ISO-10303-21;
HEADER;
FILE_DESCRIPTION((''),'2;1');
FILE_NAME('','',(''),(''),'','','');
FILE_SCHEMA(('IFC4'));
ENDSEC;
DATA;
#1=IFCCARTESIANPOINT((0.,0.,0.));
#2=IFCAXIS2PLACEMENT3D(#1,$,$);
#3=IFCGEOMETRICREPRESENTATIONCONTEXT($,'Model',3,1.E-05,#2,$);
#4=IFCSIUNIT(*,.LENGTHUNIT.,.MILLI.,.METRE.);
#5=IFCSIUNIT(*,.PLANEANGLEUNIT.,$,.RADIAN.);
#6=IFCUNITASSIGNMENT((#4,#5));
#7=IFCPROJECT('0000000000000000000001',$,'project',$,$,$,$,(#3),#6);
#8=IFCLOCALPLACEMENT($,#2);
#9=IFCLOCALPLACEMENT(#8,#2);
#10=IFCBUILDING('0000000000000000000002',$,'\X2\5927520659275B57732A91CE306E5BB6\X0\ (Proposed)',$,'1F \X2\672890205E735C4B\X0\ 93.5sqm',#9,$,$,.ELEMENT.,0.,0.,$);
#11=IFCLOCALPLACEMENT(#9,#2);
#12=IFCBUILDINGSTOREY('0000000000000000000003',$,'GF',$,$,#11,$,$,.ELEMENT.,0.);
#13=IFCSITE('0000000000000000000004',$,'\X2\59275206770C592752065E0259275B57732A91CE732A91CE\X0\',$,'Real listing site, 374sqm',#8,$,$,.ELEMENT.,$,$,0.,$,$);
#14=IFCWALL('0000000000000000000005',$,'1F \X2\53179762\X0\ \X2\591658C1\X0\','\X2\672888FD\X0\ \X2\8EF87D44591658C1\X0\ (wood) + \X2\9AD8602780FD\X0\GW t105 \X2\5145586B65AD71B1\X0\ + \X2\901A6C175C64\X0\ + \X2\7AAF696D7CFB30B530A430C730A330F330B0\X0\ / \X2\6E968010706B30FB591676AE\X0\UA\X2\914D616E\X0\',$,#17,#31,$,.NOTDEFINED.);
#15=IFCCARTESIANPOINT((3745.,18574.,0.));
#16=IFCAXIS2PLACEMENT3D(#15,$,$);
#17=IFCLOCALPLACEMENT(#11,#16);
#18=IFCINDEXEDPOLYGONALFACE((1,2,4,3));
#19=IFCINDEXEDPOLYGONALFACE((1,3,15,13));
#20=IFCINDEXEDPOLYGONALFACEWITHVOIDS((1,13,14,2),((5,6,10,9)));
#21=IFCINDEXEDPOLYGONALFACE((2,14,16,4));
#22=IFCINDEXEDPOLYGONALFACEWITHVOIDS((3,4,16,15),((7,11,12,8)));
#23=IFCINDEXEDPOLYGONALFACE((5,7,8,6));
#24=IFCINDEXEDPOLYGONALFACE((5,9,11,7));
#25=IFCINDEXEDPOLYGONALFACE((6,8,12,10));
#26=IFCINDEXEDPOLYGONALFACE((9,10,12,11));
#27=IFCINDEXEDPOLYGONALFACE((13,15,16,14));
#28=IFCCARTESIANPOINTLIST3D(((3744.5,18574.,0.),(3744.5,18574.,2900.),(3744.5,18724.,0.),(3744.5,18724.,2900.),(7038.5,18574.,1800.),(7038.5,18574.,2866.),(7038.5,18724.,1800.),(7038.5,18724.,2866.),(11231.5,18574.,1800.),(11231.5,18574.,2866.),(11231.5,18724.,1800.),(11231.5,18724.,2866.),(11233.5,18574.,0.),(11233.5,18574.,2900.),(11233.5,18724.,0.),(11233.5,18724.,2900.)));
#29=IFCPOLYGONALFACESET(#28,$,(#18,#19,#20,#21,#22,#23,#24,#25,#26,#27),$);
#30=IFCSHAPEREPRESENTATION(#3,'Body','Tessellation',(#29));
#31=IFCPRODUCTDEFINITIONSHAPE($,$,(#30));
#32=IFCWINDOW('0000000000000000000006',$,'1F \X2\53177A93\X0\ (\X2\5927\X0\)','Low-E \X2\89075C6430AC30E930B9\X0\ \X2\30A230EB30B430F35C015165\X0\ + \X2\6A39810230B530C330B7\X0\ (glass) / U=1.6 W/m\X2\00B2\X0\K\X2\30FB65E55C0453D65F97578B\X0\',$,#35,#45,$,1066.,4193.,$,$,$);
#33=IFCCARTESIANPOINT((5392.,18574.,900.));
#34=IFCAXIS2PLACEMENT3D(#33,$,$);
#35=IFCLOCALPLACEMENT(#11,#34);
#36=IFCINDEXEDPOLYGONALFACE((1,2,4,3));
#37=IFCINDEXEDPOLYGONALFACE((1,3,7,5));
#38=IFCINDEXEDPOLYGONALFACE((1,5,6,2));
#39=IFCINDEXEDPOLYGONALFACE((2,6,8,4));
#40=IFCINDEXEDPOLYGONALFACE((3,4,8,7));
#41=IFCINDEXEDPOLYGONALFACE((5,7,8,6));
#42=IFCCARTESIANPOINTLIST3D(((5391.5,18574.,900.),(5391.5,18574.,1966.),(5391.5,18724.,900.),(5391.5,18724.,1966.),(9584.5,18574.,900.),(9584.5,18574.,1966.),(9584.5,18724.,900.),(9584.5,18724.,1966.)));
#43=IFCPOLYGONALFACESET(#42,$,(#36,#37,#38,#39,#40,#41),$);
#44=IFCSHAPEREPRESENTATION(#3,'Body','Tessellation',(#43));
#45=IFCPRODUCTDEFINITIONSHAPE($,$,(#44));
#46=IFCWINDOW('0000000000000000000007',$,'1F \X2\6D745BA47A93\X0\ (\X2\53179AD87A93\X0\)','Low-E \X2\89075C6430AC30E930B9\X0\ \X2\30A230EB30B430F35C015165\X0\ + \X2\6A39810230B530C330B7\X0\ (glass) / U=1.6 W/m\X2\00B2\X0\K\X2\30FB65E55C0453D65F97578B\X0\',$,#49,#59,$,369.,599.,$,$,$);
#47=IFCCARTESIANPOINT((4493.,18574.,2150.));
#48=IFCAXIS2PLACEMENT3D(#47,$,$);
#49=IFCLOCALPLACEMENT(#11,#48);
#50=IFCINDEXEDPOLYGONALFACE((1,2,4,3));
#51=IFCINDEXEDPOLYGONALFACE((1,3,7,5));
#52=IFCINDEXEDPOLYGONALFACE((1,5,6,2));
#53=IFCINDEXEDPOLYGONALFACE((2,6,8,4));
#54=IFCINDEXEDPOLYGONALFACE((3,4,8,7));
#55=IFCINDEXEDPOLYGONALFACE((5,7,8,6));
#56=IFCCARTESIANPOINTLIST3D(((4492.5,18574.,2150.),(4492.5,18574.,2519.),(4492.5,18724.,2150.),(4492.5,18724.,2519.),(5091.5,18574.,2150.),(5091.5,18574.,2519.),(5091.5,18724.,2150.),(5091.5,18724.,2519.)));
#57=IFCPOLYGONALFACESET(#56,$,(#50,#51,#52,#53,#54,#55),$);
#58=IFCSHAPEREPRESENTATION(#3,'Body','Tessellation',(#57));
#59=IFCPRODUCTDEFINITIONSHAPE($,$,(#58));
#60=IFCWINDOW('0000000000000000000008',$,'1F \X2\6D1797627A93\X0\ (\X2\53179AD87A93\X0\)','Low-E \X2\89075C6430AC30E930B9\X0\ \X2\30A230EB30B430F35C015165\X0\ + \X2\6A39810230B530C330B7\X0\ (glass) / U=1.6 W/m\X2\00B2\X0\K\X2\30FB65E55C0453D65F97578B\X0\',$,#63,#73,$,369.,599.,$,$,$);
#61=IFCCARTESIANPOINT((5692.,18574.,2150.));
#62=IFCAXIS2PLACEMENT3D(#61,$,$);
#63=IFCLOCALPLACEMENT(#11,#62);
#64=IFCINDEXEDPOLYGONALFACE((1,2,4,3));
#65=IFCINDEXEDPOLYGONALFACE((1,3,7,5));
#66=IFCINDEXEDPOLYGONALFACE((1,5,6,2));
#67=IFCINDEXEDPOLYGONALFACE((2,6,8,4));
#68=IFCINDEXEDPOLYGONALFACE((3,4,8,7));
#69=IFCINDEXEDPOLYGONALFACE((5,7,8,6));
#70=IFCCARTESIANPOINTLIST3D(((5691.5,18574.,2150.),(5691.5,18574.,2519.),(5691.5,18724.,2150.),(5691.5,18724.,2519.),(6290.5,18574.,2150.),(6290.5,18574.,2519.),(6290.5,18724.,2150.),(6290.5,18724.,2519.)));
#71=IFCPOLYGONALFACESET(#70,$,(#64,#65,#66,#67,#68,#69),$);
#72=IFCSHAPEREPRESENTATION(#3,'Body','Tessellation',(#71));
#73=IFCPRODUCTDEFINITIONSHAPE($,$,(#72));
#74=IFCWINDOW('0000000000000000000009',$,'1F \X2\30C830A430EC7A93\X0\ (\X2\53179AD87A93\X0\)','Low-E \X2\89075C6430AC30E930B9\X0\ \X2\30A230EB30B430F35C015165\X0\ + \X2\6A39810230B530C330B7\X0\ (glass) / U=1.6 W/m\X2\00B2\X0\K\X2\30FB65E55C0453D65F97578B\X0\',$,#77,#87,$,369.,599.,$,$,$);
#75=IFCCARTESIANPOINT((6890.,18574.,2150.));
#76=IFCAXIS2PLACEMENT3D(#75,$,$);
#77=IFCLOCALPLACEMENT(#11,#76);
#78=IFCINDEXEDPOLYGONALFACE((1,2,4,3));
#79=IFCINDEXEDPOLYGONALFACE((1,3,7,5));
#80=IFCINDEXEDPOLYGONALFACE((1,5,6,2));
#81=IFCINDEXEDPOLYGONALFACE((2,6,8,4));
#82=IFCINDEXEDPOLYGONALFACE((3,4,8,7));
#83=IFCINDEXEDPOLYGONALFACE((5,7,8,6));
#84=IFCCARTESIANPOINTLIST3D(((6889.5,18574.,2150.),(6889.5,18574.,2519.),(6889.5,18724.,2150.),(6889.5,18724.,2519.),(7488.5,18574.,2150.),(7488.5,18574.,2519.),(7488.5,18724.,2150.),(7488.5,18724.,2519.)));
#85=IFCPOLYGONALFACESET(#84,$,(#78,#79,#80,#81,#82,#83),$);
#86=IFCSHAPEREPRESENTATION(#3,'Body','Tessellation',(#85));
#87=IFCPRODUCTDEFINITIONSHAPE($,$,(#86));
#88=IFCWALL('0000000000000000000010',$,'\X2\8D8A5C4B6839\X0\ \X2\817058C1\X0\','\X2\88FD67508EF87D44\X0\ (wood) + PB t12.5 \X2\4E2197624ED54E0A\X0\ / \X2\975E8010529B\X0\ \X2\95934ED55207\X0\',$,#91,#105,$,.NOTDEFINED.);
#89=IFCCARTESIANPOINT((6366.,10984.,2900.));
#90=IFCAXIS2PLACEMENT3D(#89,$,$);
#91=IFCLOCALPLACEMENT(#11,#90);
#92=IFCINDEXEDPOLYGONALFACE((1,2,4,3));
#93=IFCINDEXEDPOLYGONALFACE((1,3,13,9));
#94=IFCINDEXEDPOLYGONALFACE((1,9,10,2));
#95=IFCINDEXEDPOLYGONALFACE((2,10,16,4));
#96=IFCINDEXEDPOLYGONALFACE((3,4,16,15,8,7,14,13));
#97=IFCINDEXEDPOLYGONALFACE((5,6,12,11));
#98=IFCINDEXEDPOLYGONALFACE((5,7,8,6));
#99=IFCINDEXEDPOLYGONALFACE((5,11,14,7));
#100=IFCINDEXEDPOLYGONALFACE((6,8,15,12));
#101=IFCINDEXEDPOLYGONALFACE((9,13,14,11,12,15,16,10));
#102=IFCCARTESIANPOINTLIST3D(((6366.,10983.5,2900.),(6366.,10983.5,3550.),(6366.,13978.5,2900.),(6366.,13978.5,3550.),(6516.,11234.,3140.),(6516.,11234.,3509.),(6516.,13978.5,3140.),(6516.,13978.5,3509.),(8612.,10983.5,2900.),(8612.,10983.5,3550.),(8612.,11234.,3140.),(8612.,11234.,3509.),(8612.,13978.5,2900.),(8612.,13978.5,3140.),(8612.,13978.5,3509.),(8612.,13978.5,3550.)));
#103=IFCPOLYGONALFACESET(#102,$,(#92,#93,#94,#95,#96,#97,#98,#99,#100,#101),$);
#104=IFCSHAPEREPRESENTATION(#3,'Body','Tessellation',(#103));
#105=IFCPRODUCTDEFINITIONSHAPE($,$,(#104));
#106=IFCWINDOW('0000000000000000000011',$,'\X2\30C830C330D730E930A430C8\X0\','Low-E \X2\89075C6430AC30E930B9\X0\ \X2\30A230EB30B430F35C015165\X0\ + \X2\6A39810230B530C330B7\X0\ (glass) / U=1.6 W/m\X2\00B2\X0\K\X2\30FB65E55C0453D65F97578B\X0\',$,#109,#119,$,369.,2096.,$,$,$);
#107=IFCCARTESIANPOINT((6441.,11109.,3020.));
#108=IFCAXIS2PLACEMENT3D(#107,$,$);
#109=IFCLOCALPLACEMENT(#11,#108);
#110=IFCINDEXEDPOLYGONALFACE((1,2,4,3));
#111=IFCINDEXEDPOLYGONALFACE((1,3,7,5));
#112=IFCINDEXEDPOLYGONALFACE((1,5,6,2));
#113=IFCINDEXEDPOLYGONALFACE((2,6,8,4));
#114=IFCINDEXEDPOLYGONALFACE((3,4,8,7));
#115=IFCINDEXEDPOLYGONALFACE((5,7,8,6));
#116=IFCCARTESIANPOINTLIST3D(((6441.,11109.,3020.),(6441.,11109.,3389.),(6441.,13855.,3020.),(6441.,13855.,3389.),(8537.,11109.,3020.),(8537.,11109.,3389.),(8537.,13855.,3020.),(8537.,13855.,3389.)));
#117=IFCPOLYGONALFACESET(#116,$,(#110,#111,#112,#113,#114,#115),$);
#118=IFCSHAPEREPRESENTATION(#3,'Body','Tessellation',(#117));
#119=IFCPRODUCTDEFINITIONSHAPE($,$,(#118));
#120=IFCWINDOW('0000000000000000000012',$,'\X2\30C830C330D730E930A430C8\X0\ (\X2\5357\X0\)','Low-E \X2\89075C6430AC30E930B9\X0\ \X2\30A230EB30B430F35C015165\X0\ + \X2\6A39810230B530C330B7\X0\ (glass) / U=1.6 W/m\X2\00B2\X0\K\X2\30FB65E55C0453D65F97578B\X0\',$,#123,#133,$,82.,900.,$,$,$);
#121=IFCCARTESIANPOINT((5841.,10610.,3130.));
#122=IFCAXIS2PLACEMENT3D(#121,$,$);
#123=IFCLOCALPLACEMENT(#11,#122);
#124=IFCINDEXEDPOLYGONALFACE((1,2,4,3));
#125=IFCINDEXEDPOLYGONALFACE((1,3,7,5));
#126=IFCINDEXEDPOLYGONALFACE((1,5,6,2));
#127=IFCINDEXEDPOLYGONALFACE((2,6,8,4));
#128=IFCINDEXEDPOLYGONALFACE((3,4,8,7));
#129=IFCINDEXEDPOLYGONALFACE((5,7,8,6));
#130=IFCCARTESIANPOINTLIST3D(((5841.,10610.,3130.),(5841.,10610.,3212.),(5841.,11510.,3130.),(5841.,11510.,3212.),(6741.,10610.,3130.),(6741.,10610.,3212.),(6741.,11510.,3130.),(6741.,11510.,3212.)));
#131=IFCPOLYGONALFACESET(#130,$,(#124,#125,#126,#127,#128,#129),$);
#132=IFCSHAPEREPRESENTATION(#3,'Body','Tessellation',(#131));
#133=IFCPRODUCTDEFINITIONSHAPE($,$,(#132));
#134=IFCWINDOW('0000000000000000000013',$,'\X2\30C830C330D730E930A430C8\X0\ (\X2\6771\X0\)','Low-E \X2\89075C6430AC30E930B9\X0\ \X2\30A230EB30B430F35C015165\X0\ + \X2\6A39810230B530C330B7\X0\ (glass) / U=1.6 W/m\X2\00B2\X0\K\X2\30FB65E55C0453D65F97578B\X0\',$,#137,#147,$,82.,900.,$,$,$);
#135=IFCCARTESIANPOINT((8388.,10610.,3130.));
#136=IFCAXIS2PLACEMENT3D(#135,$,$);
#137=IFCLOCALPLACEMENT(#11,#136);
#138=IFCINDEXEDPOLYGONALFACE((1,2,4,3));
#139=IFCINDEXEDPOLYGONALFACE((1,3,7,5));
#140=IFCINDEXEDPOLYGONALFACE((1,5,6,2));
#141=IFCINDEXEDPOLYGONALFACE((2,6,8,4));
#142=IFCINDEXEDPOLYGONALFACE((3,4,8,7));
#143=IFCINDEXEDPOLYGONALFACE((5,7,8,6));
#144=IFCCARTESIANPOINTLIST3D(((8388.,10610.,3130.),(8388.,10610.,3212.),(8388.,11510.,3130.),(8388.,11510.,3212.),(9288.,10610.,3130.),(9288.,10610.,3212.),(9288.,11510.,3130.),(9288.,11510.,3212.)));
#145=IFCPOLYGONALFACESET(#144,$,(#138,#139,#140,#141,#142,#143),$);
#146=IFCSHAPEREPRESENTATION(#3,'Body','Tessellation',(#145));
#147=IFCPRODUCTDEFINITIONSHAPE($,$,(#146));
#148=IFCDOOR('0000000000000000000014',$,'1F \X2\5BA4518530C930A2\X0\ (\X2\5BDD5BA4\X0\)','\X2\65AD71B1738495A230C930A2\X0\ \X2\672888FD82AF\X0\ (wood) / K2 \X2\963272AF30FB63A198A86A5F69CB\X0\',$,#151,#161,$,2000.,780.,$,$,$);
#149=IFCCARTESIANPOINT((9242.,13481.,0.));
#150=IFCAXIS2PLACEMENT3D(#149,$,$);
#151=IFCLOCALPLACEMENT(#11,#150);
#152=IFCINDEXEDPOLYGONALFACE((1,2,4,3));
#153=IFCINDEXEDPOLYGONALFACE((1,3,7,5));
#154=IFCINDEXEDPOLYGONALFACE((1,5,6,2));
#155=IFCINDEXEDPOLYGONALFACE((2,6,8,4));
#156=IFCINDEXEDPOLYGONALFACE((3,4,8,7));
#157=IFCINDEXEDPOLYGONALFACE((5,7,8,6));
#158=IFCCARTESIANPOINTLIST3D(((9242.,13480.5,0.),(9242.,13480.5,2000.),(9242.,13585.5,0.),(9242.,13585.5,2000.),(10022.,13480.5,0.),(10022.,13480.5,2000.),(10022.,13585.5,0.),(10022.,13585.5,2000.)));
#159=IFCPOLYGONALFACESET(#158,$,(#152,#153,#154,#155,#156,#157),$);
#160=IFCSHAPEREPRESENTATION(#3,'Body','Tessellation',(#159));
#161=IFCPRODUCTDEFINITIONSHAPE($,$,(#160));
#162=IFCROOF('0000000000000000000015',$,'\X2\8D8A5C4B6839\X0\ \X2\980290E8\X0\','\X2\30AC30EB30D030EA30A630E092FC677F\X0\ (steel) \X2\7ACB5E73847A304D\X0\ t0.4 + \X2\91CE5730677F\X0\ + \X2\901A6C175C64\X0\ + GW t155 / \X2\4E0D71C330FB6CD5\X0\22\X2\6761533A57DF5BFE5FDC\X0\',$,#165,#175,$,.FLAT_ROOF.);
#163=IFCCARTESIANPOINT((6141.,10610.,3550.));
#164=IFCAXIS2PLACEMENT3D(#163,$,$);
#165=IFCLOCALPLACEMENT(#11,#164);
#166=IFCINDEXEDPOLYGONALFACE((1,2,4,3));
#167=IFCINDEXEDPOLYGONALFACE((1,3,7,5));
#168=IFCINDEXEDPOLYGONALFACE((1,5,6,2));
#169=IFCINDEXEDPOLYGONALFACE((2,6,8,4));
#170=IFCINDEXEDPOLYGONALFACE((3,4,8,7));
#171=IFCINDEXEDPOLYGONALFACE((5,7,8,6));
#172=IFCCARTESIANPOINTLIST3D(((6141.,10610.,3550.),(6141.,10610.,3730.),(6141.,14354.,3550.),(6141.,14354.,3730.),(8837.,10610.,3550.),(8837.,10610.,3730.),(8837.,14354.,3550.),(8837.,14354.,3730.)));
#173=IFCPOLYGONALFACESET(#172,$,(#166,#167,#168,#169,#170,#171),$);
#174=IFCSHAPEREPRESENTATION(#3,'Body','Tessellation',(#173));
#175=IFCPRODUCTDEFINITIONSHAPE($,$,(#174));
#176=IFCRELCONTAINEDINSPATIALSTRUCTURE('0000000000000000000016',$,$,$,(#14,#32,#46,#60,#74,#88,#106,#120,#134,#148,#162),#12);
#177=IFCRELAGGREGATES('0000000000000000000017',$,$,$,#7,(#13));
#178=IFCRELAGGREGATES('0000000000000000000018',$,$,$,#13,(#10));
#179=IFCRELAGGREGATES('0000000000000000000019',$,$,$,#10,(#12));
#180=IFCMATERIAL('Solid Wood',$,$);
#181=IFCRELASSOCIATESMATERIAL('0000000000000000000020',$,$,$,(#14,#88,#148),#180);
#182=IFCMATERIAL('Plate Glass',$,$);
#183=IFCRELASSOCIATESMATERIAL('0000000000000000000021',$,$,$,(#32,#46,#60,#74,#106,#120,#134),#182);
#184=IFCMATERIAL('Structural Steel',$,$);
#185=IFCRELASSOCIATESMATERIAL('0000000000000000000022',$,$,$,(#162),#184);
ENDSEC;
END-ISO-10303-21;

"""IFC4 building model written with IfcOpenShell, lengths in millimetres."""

from ifc_helpers import new_model, si_unit, frame, frame_2d, origin, place, context, project, spatial, rectangle, extrude, material, element, fill, save


model = new_model("IFC4")

# Units and contexts
model_context = context("Model", 3, precision=1e-05, world=origin())
ifc_project = project(units=[si_unit("LENGTHUNIT", "METRE", prefix="MILLI"), si_unit("PLANEANGLEUNIT", "RADIAN")], contexts=[model_context])

# Site, building, storey
site_placement = place(None, origin())
site = spatial("IfcSite", under=ifc_project, at=site_placement, Name="大分県大分市大字猪野猪野", ObjectType="Real listing site, 374sqm", CompositionType="ELEMENT", RefElevation=0.0)
building_placement = place(site_placement, origin())
building = spatial("IfcBuilding", under=site, at=building_placement, Name="大分大字猪野の家 (Proposed)", ObjectType="1F 木造平屋 93.5sqm", CompositionType="ELEMENT", ElevationOfRefHeight=0.0, ElevationOfTerrain=0.0)
storey_placement = place(building_placement, origin())
storey = spatial("IfcBuildingStorey", under=building, at=storey_placement, Name="GF", CompositionType="ELEMENT", Elevation=0.0)

# Shared definitions
ifc_material_1 = material(Name="Solid Wood")

# Wall, openings, windows
wall_1_placement = place(storey_placement, frame((3745.0, 18574.0, 0.0)))
wall_1 = element("IfcWall", 1, at=wall_1_placement, inside=storey, material=ifc_material_1, Name="1F 北面 外壁", Description="木製 軸組外壁 (wood) + 高性能GW t105 充填断熱 + 通気層 + 窯業系サイディング / 準耐火・外皮UA配慮", PredefinedType="NOTDEFINED", context=model_context, shape_type="SweptSolid", body=[
    extrude(rectangle(XDim=7489.0, YDim=150.0, at=frame_2d((3744.0, 75.0))), frame((3745.0, 18574.0, 0.0)), (0.0, 0.0, 1.0), 2900.0),
])
opening_1_placement = place(storey_placement, frame((5392.0, 18574.0, 900.0)))
opening_1 = element("IfcOpeningElement", 2, at=opening_1_placement, cuts=wall_1, PredefinedType="NOTDEFINED", context=model_context, shape_type="SweptSolid", body=[
    extrude(rectangle(XDim=4193.0, YDim=150.0, at=frame_2d((2096.0, 75.0))), frame((5392.0, 18574.0, 900.0)), (0.0, 0.0, 1.0), 1066.0),
])
opening_2_placement = place(storey_placement, frame((4493.0, 18574.0, 2150.0)))
opening_2 = element("IfcOpeningElement", 3, at=opening_2_placement, cuts=wall_1, PredefinedType="NOTDEFINED", context=model_context, shape_type="SweptSolid", body=[
    extrude(rectangle(XDim=599.0, YDim=150.0, at=frame_2d((299.0, 75.0))), frame((4493.0, 18574.0, 2150.0)), (0.0, 0.0, 1.0), 369.0),
])
opening_3_placement = place(storey_placement, frame((5692.0, 18574.0, 2150.0)))
opening_3 = element("IfcOpeningElement", 4, at=opening_3_placement, cuts=wall_1, PredefinedType="NOTDEFINED", context=model_context, shape_type="SweptSolid", body=[
    extrude(rectangle(XDim=599.0, YDim=150.0, at=frame_2d((299.0, 75.0))), frame((5692.0, 18574.0, 2150.0)), (0.0, 0.0, 1.0), 369.0),
])
opening_4_placement = place(storey_placement, frame((6890.0, 18574.0, 2150.0)))
opening_4 = element("IfcOpeningElement", 5, at=opening_4_placement, cuts=wall_1, PredefinedType="NOTDEFINED", context=model_context, shape_type="SweptSolid", body=[
    extrude(rectangle(XDim=599.0, YDim=150.0, at=frame_2d((299.0, 75.0))), frame((6890.0, 18574.0, 2150.0)), (0.0, 0.0, 1.0), 369.0),
])
ifc_material_2 = material(Name="Plate Glass")
window_1_placement = place(storey_placement, frame((5392.0, 18574.0, 900.0)))
window_1 = element("IfcWindow", 6, at=window_1_placement, inside=storey, material=ifc_material_2, Name="1F 北窓 (大)", Description="Low-E 複層ガラス アルゴン封入 + 樹脂サッシ (glass) / U=1.6 W/m²K・日射取得型", OverallHeight=1066.0, OverallWidth=4193.0, context=model_context, shape_type="SweptSolid", body=[
    extrude(rectangle(XDim=4193.0, YDim=150.0, at=frame_2d((2096.0, 75.0))), frame((5392.0, 18574.0, 900.0)), (0.0, 0.0, 1.0), 1066.0),
])
fill(opening_1, window_1)
window_2_placement = place(storey_placement, frame((4493.0, 18574.0, 2150.0)))
window_2 = element("IfcWindow", 7, at=window_2_placement, inside=storey, material=ifc_material_2, Name="1F 浴室窓 (北高窓)", Description="Low-E 複層ガラス アルゴン封入 + 樹脂サッシ (glass) / U=1.6 W/m²K・日射取得型", OverallHeight=369.0, OverallWidth=599.0, context=model_context, shape_type="SweptSolid", body=[
    extrude(rectangle(XDim=599.0, YDim=150.0, at=frame_2d((299.0, 75.0))), frame((4493.0, 18574.0, 2150.0)), (0.0, 0.0, 1.0), 369.0),
])
fill(opening_2, window_2)
window_3_placement = place(storey_placement, frame((5692.0, 18574.0, 2150.0)))
window_3 = element("IfcWindow", 8, at=window_3_placement, inside=storey, material=ifc_material_2, Name="1F 洗面窓 (北高窓)", Description="Low-E 複層ガラス アルゴン封入 + 樹脂サッシ (glass) / U=1.6 W/m²K・日射取得型", OverallHeight=369.0, OverallWidth=599.0, context=model_context, shape_type="SweptSolid", body=[
    extrude(rectangle(XDim=599.0, YDim=150.0, at=frame_2d((299.0, 75.0))), frame((5692.0, 18574.0, 2150.0)), (0.0, 0.0, 1.0), 369.0),
])
fill(opening_3, window_3)
window_4_placement = place(storey_placement, frame((6890.0, 18574.0, 2150.0)))
window_4 = element("IfcWindow", 9, at=window_4_placement, inside=storey, material=ifc_material_2, Name="1F トイレ窓 (北高窓)", Description="Low-E 複層ガラス アルゴン封入 + 樹脂サッシ (glass) / U=1.6 W/m²K・日射取得型", OverallHeight=369.0, OverallWidth=599.0, context=model_context, shape_type="SweptSolid", body=[
    extrude(rectangle(XDim=599.0, YDim=150.0, at=frame_2d((299.0, 75.0))), frame((6890.0, 18574.0, 2150.0)), (0.0, 0.0, 1.0), 369.0),
])
fill(opening_4, window_4)

# Wall, openings, windows
wall_2_placement = place(storey_placement, frame((6366.0, 10984.0, 2900.0)))
wall_2 = element("IfcWall", 10, at=wall_2_placement, inside=storey, material=ifc_material_1, Name="越屋根 腰壁", Description="製材軸組 (wood) + PB t12.5 両面仕上 / 非耐力 間仕切", PredefinedType="NOTDEFINED", context=model_context, shape_type="SweptSolid", body=[
    extrude(rectangle(XDim=2246.0, YDim=2995.0, at=frame_2d((1123.0, 1497.0))), frame((6366.0, 10984.0, 2900.0)), (0.0, 0.0, 1.0), 650.0),
])
opening_5_placement = place(storey_placement, frame((6441.0, 11109.0, 3020.0)))
opening_5 = element("IfcOpeningElement", 11, at=opening_5_placement, cuts=wall_2, PredefinedType="NOTDEFINED", context=model_context, shape_type="SweptSolid", body=[
    extrude(rectangle(XDim=2096.0, YDim=2746.0, at=frame_2d((1048.0, 1373.0))), frame((6441.0, 11109.0, 3020.0)), (0.0, 0.0, 1.0), 369.0),
])
opening_6_placement = place(storey_placement, frame((5841.0, 10610.0, 3130.0)))
opening_6 = element("IfcOpeningElement", 12, at=opening_6_placement, cuts=wall_2, PredefinedType="NOTDEFINED", context=model_context, shape_type="SweptSolid", body=[
    extrude(rectangle(XDim=900.0, YDim=900.0, at=frame_2d((450.0, 450.0))), frame((5841.0, 10610.0, 3130.0)), (0.0, 0.0, 1.0), 82.0),
])
opening_7_placement = place(storey_placement, frame((8388.0, 10610.0, 3130.0)))
opening_7 = element("IfcOpeningElement", 13, at=opening_7_placement, cuts=wall_2, PredefinedType="NOTDEFINED", context=model_context, shape_type="SweptSolid", body=[
    extrude(rectangle(XDim=900.0, YDim=900.0, at=frame_2d((450.0, 450.0))), frame((8388.0, 10610.0, 3130.0)), (0.0, 0.0, 1.0), 82.0),
])
window_5_placement = place(storey_placement, frame((6441.0, 11109.0, 3020.0)))
window_5 = element("IfcWindow", 14, at=window_5_placement, inside=storey, material=ifc_material_2, Name="トップライト", Description="Low-E 複層ガラス アルゴン封入 + 樹脂サッシ (glass) / U=1.6 W/m²K・日射取得型", OverallHeight=369.0, OverallWidth=2096.0, context=model_context, shape_type="SweptSolid", body=[
    extrude(rectangle(XDim=2096.0, YDim=2746.0, at=frame_2d((1048.0, 1373.0))), frame((6441.0, 11109.0, 3020.0)), (0.0, 0.0, 1.0), 369.0),
])
fill(opening_5, window_5)
window_6_placement = place(storey_placement, frame((5841.0, 10610.0, 3130.0)))
window_6 = element("IfcWindow", 15, at=window_6_placement, inside=storey, material=ifc_material_2, Name="トップライト (南)", Description="Low-E 複層ガラス アルゴン封入 + 樹脂サッシ (glass) / U=1.6 W/m²K・日射取得型", OverallHeight=82.0, OverallWidth=900.0, context=model_context, shape_type="SweptSolid", body=[
    extrude(rectangle(XDim=900.0, YDim=900.0, at=frame_2d((450.0, 450.0))), frame((5841.0, 10610.0, 3130.0)), (0.0, 0.0, 1.0), 82.0),
])
fill(opening_6, window_6)
window_7_placement = place(storey_placement, frame((8388.0, 10610.0, 3130.0)))
window_7 = element("IfcWindow", 16, at=window_7_placement, inside=storey, material=ifc_material_2, Name="トップライト (東)", Description="Low-E 複層ガラス アルゴン封入 + 樹脂サッシ (glass) / U=1.6 W/m²K・日射取得型", OverallHeight=82.0, OverallWidth=900.0, context=model_context, shape_type="SweptSolid", body=[
    extrude(rectangle(XDim=900.0, YDim=900.0, at=frame_2d((450.0, 450.0))), frame((8388.0, 10610.0, 3130.0)), (0.0, 0.0, 1.0), 82.0),
])
fill(opening_7, window_7)

# Door
door_1_placement = place(storey_placement, frame((9242.0, 13481.0, 0.0)))
element("IfcDoor", 17, at=door_1_placement, inside=storey, material=ifc_material_1, Name="1F 室内ドア (寝室)", Description="断熱玄関ドア 木製芯 (wood) / K2 防犯・採風機構", OverallHeight=2000.0, OverallWidth=780.0, context=model_context, shape_type="SweptSolid", body=[
    extrude(rectangle(XDim=780.0, YDim=105.0, at=frame_2d((390.0, 52.0))), frame((9242.0, 13481.0, 0.0)), (0.0, 0.0, 1.0), 2000.0),
])

# Roof
ifc_material_3 = material(Name="Structural Steel")
roof_placement = place(storey_placement, frame((6141.0, 10610.0, 3550.0)))
element("IfcRoof", 18, at=roof_placement, inside=storey, material=ifc_material_3, Name="越屋根 頂部", Description="ガルバリウム鋼板 (steel) 立平葺き t0.4 + 野地板 + 通気層 + GW t155 / 不燃・法22条区域対応", PredefinedType="FLAT_ROOF", context=model_context, shape_type="SweptSolid", body=[
    extrude(rectangle(XDim=2696.0, YDim=3744.0, at=frame_2d((1348.0, 1872.0))), frame((6141.0, 10610.0, 3550.0)), (0.0, 0.0, 1.0), 180.0),
])

save(model, "model.ifc")
